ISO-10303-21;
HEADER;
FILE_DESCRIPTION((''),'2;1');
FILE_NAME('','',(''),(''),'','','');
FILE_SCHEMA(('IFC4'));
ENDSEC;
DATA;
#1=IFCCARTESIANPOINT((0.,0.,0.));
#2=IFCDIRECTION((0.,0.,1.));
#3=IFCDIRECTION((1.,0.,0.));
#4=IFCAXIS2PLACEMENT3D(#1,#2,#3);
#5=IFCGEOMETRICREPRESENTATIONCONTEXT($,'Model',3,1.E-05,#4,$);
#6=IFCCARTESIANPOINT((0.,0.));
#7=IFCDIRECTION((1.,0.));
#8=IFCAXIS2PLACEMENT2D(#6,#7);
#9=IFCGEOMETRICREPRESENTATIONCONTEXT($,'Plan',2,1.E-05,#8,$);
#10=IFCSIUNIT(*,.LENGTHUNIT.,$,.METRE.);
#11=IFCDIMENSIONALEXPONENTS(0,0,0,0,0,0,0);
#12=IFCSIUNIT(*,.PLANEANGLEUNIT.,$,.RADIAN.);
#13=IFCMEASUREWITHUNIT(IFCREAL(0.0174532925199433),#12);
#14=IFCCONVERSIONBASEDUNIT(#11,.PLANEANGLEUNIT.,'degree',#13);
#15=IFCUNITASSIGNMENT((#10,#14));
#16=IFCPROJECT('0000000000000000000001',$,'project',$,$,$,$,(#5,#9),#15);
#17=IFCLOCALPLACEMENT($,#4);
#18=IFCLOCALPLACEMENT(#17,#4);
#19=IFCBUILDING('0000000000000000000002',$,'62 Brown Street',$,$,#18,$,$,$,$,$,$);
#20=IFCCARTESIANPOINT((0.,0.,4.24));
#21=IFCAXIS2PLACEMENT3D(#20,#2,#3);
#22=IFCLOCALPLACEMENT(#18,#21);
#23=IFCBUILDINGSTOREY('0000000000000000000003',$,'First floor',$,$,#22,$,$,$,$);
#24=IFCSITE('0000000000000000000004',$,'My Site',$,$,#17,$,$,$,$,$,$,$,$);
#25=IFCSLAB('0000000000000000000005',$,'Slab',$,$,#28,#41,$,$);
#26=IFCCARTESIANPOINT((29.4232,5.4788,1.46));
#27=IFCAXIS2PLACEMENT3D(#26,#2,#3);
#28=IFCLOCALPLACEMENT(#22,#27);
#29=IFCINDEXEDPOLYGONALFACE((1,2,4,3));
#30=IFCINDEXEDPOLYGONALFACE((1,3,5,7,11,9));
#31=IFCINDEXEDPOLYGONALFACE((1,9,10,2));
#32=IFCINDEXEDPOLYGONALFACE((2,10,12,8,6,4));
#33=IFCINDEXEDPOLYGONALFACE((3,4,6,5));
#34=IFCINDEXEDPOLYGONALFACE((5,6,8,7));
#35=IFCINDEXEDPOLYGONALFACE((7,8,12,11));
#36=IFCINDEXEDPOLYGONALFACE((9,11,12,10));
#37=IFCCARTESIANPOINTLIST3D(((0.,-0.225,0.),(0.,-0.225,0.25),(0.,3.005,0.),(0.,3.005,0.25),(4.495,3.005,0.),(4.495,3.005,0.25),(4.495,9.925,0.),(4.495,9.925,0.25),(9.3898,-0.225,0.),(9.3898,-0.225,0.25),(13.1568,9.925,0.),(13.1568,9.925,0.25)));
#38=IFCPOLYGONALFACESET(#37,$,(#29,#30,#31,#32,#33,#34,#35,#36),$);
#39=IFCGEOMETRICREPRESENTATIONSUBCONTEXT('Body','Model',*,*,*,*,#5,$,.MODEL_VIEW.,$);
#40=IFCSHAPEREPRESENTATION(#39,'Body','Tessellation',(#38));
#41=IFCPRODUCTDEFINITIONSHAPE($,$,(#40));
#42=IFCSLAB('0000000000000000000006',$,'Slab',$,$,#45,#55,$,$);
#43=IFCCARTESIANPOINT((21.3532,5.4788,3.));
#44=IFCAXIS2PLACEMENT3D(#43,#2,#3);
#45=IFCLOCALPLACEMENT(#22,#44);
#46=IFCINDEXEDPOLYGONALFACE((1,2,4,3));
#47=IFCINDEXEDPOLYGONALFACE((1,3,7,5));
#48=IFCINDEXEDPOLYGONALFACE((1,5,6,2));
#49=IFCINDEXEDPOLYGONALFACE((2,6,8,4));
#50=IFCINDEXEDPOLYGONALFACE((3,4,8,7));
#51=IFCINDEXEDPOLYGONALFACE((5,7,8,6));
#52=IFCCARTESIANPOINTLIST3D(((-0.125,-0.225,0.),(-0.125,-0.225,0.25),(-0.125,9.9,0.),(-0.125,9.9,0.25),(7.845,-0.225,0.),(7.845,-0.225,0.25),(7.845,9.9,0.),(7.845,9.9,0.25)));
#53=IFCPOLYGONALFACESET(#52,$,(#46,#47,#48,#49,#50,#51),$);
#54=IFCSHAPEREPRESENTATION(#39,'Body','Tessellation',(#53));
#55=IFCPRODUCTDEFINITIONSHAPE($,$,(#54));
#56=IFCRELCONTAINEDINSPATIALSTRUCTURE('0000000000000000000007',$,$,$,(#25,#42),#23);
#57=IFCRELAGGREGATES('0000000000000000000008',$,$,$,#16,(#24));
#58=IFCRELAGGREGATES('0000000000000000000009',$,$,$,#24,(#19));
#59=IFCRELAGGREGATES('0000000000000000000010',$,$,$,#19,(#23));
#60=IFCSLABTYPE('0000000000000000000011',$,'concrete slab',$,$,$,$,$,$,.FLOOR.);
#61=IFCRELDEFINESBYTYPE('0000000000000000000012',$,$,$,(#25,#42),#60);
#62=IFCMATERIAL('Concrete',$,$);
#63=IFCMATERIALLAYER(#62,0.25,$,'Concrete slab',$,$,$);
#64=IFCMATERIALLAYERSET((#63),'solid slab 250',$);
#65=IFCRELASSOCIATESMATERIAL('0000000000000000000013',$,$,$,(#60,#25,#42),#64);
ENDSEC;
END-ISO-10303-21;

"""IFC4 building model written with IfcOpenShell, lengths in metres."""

from ifc_helpers import new_model, entity, si_unit, converted_unit, frame, origin_with_axes, origin_2d_with_axis, place, context, subcontext, project, spatial, line, indexed_curve, outline, extrude, material, layer, layer_set, layer_usage, type_object, element, save


model = new_model("IFC4")

# Units and contexts
model_context = context("Model", 3, precision=1e-05, world=origin_with_axes())
plan_context = context("Plan", 2, precision=1e-05, world=origin_2d_with_axis())
body_context_1 = subcontext(model_context, "Body", "Model", "MODEL_VIEW")
ifc_project = project(units=[si_unit("LENGTHUNIT", "METRE"), converted_unit("PLANEANGLEUNIT", "degree", entity("IfcReal", 0.0174532925199433), si_unit("PLANEANGLEUNIT", "RADIAN"), dimensions=[0, 0, 0, 0, 0, 0, 0])], contexts=[model_context, plan_context])

# Site, building, storey
site_placement = place(None, origin_with_axes())
site = spatial("IfcSite", under=ifc_project, at=site_placement, Name="My Site")
building_placement = place(site_placement, origin_with_axes())
building = spatial("IfcBuilding", under=site, at=building_placement, Name="62 Brown Street")
storey_placement = place(building_placement, frame((0.0, 0.0, 4.24), z_axis=(0.0, 0.0, 1.0), x_axis=(1.0, 0.0, 0.0)))
storey = spatial("IfcBuildingStorey", under=building, at=storey_placement, Name="First floor")

# Slabs
ifc_material_1 = material(Name="Concrete")
ifc_layer_1 = layer(ifc_material_1, 0.25, Name="Concrete slab")
ifc_layer_set_1 = layer_set([ifc_layer_1], Name="solid slab 250")
slab_type = type_object("IfcSlabType", Name="concrete slab", PredefinedType="FLOOR", material=ifc_layer_set_1)
ifc_layer_usage_1 = layer_usage(ifc_layer_set_1, "AXIS3", "POSITIVE", 0.0)
slab_1_placement = place(storey_placement, frame((29.4232, 5.4788, 1.46), z_axis=(0.0, 0.0, 1.0), x_axis=(1.0, 0.0, 0.0)))
element("IfcSlab", 1, at=slab_1_placement, inside=storey, type_object=slab_type, material=ifc_layer_usage_1, Name="Slab", context=body_context_1, shape_type="SweptSolid", body=[
    extrude(outline(indexed_curve([(0.0, 3.005), (0.0, -0.225), (9.3898, -0.225), (13.1568, 9.925), (4.495, 9.925), (4.495, 3.005)], segments=[line(4, 3), line(3, 2), line(2, 1), line(1, 6), line(6, 5), line(5, 4)], self_intersect=False)), None, (0.0, 0.0, 1.0), 0.25),
])
ifc_layer_usage_2 = layer_usage(ifc_layer_set_1, "AXIS3", "POSITIVE", 0.0)
slab_2_placement = place(storey_placement, frame((21.3532, 5.4788, 3.0), z_axis=(0.0, 0.0, 1.0), x_axis=(1.0, 0.0, 0.0)))
element("IfcSlab", 2, at=slab_2_placement, inside=storey, type_object=slab_type, material=ifc_layer_usage_2, Name="Slab", context=body_context_1, shape_type="SweptSolid", body=[
    extrude(outline(indexed_curve([(7.845, -0.225), (-0.125, -0.225), (-0.125, 9.9), (7.845, 9.9)], segments=[line(4, 1), line(1, 2), line(2, 3), line(3, 4)], self_intersect=False)), None, (0.0, 0.0, 1.0), 0.25),
])

save(model, "model.ifc")
